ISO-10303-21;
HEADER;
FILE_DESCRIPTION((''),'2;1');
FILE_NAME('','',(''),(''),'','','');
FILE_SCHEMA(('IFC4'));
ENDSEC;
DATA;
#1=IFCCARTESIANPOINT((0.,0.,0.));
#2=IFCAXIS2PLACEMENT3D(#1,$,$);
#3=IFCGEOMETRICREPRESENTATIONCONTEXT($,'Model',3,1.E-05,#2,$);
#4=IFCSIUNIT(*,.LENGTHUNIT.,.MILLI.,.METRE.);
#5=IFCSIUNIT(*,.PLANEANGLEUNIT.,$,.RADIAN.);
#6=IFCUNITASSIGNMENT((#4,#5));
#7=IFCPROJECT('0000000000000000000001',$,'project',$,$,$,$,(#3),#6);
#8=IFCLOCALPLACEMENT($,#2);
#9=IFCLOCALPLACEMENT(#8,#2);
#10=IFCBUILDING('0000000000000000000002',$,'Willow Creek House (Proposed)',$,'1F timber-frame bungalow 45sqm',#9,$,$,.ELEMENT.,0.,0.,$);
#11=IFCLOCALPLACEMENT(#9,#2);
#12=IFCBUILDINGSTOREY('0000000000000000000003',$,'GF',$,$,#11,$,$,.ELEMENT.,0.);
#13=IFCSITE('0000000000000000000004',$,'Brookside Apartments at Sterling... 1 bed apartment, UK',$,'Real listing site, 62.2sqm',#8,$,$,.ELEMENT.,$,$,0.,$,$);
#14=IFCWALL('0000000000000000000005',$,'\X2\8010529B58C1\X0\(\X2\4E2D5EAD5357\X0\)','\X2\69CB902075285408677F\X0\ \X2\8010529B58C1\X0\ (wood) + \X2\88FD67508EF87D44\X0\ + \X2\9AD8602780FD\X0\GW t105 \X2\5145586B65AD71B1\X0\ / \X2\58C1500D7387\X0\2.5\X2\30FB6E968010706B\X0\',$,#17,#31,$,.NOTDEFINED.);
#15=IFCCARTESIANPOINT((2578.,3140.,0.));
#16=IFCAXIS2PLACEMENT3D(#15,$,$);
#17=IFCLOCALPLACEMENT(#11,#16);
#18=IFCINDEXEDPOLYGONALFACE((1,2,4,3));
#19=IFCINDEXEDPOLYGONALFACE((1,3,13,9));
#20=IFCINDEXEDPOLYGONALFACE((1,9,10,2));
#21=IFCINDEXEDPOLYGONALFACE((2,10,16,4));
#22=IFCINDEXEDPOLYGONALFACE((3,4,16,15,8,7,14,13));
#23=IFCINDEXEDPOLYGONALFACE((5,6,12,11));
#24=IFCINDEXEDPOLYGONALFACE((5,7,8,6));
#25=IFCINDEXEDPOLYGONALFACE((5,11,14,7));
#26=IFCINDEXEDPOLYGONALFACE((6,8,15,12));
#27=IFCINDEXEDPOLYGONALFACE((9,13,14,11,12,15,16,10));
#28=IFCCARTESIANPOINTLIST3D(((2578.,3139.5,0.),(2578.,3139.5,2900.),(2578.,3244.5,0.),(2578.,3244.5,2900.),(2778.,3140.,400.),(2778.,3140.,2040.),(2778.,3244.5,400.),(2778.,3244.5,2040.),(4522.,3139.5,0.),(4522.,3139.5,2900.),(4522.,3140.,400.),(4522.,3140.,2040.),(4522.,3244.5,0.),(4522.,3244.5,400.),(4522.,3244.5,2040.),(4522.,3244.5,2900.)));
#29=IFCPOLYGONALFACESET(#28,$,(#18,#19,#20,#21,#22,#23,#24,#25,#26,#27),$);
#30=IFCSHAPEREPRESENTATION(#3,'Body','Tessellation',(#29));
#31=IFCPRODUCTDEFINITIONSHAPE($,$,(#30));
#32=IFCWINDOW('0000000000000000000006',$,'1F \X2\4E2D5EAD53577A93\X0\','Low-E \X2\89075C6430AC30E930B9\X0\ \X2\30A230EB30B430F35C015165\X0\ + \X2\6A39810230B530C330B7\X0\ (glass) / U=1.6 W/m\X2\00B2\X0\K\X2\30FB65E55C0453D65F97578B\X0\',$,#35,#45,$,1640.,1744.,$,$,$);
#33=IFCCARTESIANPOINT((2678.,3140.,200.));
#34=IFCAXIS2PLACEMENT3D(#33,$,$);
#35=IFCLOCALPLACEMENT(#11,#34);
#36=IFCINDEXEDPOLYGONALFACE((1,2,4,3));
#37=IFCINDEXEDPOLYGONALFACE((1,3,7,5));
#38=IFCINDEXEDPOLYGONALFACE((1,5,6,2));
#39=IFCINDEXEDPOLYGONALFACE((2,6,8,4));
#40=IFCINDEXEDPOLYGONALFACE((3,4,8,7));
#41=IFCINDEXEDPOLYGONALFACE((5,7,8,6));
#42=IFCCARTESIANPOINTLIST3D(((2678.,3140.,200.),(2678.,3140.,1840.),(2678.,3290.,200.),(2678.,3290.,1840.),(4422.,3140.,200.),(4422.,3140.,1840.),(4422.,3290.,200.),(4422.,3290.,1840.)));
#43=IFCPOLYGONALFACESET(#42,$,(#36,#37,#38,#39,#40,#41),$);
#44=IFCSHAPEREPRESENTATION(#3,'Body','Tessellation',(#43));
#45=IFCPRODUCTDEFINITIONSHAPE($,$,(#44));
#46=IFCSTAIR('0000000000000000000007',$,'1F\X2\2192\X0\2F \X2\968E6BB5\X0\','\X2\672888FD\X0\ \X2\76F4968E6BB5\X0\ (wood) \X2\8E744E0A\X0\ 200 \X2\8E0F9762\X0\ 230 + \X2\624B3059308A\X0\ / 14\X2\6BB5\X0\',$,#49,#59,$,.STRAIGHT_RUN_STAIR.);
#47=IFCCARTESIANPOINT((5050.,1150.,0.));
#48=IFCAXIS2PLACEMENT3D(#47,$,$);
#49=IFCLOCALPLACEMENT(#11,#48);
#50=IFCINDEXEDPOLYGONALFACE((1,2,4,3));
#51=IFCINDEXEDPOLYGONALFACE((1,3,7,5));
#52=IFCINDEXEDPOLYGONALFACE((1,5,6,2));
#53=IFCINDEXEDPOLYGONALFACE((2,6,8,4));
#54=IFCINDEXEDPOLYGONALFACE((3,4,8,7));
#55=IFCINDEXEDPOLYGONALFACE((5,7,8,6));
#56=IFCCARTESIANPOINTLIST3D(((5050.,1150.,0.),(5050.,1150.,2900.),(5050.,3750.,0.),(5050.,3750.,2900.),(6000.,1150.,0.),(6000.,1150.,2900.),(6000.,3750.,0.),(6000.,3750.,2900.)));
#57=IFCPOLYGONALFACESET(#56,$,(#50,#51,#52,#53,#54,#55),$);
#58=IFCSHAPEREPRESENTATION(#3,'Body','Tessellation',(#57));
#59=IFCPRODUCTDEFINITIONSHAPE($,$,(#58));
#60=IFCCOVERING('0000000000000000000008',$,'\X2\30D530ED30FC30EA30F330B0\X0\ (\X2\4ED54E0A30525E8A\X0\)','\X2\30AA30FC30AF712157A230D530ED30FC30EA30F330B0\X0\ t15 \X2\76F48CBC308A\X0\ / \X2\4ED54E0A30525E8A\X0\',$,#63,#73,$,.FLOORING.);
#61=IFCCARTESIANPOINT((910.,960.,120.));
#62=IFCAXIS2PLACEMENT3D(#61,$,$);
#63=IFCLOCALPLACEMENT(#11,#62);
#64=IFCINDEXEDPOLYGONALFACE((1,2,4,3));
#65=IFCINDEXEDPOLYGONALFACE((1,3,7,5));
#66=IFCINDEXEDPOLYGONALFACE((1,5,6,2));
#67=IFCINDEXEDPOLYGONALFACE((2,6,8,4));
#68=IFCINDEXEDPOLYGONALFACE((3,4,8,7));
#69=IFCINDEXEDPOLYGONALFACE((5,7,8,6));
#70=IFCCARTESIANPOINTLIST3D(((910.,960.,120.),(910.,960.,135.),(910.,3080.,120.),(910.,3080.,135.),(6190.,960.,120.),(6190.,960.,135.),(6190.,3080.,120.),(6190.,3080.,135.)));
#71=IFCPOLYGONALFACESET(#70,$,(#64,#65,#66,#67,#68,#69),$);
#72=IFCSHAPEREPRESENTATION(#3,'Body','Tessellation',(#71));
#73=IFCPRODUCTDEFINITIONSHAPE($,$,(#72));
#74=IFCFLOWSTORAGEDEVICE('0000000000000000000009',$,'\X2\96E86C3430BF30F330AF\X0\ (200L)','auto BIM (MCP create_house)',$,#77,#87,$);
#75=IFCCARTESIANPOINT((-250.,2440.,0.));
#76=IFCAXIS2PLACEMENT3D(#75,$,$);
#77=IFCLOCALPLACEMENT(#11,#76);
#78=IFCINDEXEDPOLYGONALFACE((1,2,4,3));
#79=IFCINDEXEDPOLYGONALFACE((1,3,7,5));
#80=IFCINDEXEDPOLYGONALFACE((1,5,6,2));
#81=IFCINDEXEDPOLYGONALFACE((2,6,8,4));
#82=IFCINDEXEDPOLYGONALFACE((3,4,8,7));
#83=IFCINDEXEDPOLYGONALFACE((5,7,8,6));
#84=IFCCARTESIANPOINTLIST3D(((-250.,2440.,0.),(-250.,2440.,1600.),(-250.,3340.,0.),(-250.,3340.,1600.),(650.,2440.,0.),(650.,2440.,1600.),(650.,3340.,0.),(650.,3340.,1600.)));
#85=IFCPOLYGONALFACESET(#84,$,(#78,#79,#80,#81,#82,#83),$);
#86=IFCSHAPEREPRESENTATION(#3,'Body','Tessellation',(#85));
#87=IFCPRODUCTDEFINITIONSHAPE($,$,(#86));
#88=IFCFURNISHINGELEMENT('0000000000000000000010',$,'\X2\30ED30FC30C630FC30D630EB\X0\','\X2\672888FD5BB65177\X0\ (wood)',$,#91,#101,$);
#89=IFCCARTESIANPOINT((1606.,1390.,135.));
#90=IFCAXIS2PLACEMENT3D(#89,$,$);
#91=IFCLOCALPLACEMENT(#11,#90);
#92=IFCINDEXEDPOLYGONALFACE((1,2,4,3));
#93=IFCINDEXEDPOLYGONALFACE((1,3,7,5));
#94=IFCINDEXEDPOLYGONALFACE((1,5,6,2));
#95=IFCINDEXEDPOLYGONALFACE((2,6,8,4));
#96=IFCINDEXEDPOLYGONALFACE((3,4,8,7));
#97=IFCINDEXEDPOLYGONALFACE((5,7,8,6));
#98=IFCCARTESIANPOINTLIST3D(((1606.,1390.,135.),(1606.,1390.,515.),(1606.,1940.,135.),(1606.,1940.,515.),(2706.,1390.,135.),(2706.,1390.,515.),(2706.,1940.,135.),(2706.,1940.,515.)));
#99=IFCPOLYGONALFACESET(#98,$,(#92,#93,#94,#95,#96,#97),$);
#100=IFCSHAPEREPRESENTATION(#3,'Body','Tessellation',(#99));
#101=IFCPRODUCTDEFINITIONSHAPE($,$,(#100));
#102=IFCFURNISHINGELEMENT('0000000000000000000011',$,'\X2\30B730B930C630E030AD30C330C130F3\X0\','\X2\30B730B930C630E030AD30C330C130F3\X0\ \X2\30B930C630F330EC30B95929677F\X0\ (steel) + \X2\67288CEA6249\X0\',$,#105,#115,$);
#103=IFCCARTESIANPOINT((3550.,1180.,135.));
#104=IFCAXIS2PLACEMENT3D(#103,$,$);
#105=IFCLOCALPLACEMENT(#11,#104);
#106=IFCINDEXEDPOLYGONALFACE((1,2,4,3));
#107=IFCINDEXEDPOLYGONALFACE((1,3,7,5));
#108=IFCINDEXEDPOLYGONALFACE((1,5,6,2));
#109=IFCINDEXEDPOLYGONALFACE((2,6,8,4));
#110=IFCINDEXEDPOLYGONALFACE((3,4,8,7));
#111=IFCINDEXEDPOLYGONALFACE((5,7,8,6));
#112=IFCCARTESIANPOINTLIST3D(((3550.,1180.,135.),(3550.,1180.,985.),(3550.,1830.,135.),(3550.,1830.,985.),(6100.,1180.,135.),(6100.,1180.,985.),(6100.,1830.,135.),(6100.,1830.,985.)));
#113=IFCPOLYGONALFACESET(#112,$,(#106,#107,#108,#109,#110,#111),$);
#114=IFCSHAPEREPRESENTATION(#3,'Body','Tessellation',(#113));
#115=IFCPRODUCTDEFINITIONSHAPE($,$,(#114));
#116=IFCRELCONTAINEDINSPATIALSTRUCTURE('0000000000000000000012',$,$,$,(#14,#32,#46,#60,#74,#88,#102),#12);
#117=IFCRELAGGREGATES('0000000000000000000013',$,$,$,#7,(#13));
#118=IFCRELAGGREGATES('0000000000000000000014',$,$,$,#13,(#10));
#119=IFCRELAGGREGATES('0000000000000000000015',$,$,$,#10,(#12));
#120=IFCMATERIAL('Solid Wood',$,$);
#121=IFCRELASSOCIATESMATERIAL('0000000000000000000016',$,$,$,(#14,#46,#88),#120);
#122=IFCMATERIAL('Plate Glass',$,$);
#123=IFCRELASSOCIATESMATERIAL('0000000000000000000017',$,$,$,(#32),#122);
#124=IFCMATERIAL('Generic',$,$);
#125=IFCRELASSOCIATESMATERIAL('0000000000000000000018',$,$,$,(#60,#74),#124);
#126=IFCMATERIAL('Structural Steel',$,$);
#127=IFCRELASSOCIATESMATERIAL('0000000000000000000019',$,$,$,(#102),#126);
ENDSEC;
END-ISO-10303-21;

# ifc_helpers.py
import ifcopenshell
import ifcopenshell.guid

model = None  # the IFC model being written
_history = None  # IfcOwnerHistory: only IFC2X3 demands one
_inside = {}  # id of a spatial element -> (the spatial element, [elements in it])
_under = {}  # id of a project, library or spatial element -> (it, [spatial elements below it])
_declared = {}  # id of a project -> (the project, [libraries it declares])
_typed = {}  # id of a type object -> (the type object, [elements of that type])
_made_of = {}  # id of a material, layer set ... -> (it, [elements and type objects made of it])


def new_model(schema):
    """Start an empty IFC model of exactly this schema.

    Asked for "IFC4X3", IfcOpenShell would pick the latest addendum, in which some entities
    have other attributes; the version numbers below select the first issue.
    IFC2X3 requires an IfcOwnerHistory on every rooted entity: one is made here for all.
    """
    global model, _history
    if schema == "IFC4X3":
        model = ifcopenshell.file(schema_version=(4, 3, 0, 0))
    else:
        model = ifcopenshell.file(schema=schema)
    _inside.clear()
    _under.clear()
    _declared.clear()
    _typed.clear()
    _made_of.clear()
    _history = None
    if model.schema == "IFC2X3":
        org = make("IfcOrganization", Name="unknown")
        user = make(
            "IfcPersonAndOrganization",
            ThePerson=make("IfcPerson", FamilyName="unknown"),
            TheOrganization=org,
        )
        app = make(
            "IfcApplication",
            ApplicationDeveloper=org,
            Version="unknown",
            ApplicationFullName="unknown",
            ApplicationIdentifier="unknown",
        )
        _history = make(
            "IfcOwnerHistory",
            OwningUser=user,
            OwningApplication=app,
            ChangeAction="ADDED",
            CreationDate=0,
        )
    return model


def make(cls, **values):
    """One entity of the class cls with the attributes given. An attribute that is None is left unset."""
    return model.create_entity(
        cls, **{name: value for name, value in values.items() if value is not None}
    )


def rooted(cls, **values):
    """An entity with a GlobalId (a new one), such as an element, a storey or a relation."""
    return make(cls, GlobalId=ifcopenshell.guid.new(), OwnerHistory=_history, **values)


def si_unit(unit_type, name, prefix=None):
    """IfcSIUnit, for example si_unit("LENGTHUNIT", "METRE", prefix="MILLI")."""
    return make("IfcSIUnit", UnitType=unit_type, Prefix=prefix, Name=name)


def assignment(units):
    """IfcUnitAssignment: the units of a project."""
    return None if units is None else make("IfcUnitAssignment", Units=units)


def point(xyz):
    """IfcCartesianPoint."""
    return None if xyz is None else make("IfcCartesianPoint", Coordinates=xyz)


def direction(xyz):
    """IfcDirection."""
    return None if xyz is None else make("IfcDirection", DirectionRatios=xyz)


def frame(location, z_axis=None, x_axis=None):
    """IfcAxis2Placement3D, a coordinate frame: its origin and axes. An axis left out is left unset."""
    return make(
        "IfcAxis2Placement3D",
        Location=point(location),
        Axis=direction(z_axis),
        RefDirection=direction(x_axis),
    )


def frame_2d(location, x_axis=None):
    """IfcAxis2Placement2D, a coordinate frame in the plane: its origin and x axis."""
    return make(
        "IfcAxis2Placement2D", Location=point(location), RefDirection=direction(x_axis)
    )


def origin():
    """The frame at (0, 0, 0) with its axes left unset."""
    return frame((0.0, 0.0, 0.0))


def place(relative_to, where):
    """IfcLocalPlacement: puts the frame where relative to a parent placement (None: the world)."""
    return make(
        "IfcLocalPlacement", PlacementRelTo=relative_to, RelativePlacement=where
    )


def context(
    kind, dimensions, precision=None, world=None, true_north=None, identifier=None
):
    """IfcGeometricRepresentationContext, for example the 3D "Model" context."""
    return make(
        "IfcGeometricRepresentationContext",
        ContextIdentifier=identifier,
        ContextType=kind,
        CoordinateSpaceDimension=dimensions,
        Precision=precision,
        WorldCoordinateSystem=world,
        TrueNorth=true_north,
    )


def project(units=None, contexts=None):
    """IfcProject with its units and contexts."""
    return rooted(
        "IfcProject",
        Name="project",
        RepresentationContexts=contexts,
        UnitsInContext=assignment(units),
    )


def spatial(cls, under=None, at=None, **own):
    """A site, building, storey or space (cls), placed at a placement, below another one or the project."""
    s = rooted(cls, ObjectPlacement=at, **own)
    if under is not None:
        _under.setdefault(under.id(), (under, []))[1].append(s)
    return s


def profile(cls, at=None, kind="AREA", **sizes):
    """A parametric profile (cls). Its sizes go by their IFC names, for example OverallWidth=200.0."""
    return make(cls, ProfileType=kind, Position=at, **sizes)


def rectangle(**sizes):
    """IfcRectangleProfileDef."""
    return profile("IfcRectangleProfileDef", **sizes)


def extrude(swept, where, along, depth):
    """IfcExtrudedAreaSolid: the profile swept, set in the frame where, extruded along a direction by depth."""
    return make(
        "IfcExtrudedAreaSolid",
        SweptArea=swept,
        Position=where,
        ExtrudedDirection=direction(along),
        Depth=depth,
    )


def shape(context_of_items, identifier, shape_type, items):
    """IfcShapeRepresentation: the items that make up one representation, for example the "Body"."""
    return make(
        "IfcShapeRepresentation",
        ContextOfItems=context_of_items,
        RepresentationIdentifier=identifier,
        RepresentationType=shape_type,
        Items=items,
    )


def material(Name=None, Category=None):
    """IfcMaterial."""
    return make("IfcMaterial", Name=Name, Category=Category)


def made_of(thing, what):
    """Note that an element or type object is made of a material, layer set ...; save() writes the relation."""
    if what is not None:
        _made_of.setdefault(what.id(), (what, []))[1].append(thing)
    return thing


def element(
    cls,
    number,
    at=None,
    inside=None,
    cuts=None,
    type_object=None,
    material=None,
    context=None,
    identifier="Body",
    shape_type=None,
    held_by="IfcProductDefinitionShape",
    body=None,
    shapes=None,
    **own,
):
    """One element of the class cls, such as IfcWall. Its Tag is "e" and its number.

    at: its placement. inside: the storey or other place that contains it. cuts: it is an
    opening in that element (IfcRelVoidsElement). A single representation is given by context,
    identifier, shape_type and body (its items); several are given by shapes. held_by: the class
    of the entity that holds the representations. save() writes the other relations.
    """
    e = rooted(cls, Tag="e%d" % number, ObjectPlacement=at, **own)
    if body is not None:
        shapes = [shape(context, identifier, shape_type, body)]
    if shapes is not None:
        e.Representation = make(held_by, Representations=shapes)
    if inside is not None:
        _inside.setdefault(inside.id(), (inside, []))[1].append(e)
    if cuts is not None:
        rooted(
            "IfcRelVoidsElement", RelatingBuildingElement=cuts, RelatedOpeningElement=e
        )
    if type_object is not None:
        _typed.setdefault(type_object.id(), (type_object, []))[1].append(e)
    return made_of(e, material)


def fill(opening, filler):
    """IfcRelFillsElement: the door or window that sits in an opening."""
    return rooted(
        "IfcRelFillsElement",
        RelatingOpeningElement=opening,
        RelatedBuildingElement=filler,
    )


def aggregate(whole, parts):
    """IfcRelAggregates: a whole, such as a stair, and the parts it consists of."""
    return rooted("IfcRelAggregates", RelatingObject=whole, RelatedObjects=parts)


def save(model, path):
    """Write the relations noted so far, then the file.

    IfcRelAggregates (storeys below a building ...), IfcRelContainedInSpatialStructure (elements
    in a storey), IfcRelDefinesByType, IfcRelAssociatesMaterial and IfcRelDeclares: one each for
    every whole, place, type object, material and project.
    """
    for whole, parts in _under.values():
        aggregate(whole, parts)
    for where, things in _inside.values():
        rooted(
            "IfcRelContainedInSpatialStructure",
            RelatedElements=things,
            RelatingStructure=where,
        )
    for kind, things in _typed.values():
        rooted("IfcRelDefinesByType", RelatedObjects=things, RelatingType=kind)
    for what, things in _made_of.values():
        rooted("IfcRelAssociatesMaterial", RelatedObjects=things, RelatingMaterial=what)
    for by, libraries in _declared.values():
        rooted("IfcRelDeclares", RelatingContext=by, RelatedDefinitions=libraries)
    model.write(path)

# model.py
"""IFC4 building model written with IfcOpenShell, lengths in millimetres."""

from ifc_helpers import new_model, si_unit, frame, frame_2d, origin, place, context, project, spatial, rectangle, extrude, material, element, fill, save


model = new_model("IFC4")

# Units and contexts
model_context = context("Model", 3, precision=1e-05, world=origin())
ifc_project = project(units=[si_unit("LENGTHUNIT", "METRE", prefix="MILLI"), si_unit("PLANEANGLEUNIT", "RADIAN")], contexts=[model_context])

# Site, building, storey
site_placement = place(None, origin())
site = spatial("IfcSite", under=ifc_project, at=site_placement, Name="Brookside Apartments at Sterling... 1 bed apartment, UK", ObjectType="Real listing site, 62.2sqm", CompositionType="ELEMENT", RefElevation=0.0)
building_placement = place(site_placement, origin())
building = spatial("IfcBuilding", under=site, at=building_placement, Name="Willow Creek House (Proposed)", ObjectType="1F timber-frame bungalow 45sqm", CompositionType="ELEMENT", ElevationOfRefHeight=0.0, ElevationOfTerrain=0.0)
storey_placement = place(building_placement, origin())
storey = spatial("IfcBuildingStorey", under=building, at=storey_placement, Name="GF", CompositionType="ELEMENT", Elevation=0.0)

# Shared definitions
ifc_material_1 = material(Name="Solid Wood")

# Shared definitions
ifc_material_2 = material(Name="Plate Glass")

# Wall, opening, window
wall_1_placement = place(storey_placement, frame((2578.0, 3140.0, 0.0)))
wall_1 = element("IfcWall", 1, at=wall_1_placement, inside=storey, material=ifc_material_1, Name="耐力壁(中庭南)", Description="構造用合板 耐力壁 (wood) + 製材軸組 + 高性能GW t105 充填断熱 / 壁倍率2.5・準耐火", PredefinedType="NOTDEFINED", context=model_context, shape_type="SweptSolid", body=[
    extrude(rectangle(XDim=1944.0, YDim=105.0, at=frame_2d((972.0, 52.0))), frame((2578.0, 3140.0, 0.0)), (0.0, 0.0, 1.0), 2900.0),
])
opening_1_placement = place(storey_placement, frame((2678.0, 3140.0, 200.0)))
opening_1 = element("IfcOpeningElement", 2, at=opening_1_placement, cuts=wall_1, PredefinedType="NOTDEFINED", context=model_context, shape_type="SweptSolid", body=[
    extrude(rectangle(XDim=1744.0, YDim=150.0, at=frame_2d((872.0, 75.0))), frame((2678.0, 3140.0, 200.0)), (0.0, 0.0, 1.0), 1640.0),
])
window_1_placement = place(storey_placement, frame((2678.0, 3140.0, 200.0)))
window_1 = element("IfcWindow", 3, at=window_1_placement, inside=storey, material=ifc_material_2, Name="1F 中庭南窓", Description="Low-E 複層ガラス アルゴン封入 + 樹脂サッシ (glass) / U=1.6 W/m²K・日射取得型", OverallHeight=1640.0, OverallWidth=1744.0, context=model_context, shape_type="SweptSolid", body=[
    extrude(rectangle(XDim=1744.0, YDim=150.0, at=frame_2d((872.0, 75.0))), frame((2678.0, 3140.0, 200.0)), (0.0, 0.0, 1.0), 1640.0),
])
fill(opening_1, window_1)

# Stair
stair_placement = place(storey_placement, frame((5050.0, 1150.0, 0.0)))
element("IfcStair", 4, at=stair_placement, inside=storey, material=ifc_material_1, Name="1F→2F 階段", Description="木製 直階段 (wood) 蹴上 200 踏面 230 + 手すり / 14段", PredefinedType="STRAIGHT_RUN_STAIR", context=model_context, shape_type="SweptSolid", body=[
    extrude(rectangle(XDim=950.0, YDim=2600.0, at=frame_2d((475.0, 1300.0))), frame((5050.0, 1150.0, 0.0)), (0.0, 0.0, 1.0), 2900.0),
])

# Covering
ifc_material_3 = material(Name="Generic")
covering_placement = place(storey_placement, frame((910.0, 960.0, 120.0)))
element("IfcCovering", 5, at=covering_placement, inside=storey, material=ifc_material_3, Name="フローリング (仕上げ床)", Description="オーク無垢フローリング t15 直貼り / 仕上げ床", PredefinedType="FLOORING", context=model_context, shape_type="SweptSolid", body=[
    extrude(rectangle(XDim=5280.0, YDim=2120.0, at=frame_2d((2640.0, 1060.0))), frame((910.0, 960.0, 120.0)), (0.0, 0.0, 1.0), 15.0),
])

# Flow storage device
flow_storage_device_placement = place(storey_placement, frame((-250.0, 2440.0, 0.0)))
element("IfcFlowStorageDevice", 6, at=flow_storage_device_placement, inside=storey, material=ifc_material_3, Name="雨水タンク (200L)", Description="auto BIM (MCP create_house)", context=model_context, shape_type="SweptSolid", body=[
    extrude(rectangle(XDim=900.0, YDim=900.0, at=frame_2d((450.0, 450.0))), frame((-250.0, 2440.0, 0.0)), (0.0, 0.0, 1.0), 1600.0),
])

# Furnishing elements
furnishing_1_placement = place(storey_placement, frame((1606.0, 1390.0, 135.0)))
element("IfcFurnishingElement", 7, at=furnishing_1_placement, inside=storey, material=ifc_material_1, Name="ローテーブル", Description="木製家具 (wood)", context=model_context, shape_type="SweptSolid", body=[
    extrude(rectangle(XDim=1100.0, YDim=550.0, at=frame_2d((550.0, 275.0))), frame((1606.0, 1390.0, 135.0)), (0.0, 0.0, 1.0), 380.0),
])
ifc_material_4 = material(Name="Structural Steel")
furnishing_2_placement = place(storey_placement, frame((3550.0, 1180.0, 135.0)))
element("IfcFurnishingElement", 8, at=furnishing_2_placement, inside=storey, material=ifc_material_4, Name="システムキッチン", Description="システムキッチン ステンレス天板 (steel) + 木質扉", context=model_context, shape_type="SweptSolid", body=[
    extrude(rectangle(XDim=2550.0, YDim=650.0, at=frame_2d((1275.0, 325.0))), frame((3550.0, 1180.0, 135.0)), (0.0, 0.0, 1.0), 850.0),
])

save(model, "model.ifc")
